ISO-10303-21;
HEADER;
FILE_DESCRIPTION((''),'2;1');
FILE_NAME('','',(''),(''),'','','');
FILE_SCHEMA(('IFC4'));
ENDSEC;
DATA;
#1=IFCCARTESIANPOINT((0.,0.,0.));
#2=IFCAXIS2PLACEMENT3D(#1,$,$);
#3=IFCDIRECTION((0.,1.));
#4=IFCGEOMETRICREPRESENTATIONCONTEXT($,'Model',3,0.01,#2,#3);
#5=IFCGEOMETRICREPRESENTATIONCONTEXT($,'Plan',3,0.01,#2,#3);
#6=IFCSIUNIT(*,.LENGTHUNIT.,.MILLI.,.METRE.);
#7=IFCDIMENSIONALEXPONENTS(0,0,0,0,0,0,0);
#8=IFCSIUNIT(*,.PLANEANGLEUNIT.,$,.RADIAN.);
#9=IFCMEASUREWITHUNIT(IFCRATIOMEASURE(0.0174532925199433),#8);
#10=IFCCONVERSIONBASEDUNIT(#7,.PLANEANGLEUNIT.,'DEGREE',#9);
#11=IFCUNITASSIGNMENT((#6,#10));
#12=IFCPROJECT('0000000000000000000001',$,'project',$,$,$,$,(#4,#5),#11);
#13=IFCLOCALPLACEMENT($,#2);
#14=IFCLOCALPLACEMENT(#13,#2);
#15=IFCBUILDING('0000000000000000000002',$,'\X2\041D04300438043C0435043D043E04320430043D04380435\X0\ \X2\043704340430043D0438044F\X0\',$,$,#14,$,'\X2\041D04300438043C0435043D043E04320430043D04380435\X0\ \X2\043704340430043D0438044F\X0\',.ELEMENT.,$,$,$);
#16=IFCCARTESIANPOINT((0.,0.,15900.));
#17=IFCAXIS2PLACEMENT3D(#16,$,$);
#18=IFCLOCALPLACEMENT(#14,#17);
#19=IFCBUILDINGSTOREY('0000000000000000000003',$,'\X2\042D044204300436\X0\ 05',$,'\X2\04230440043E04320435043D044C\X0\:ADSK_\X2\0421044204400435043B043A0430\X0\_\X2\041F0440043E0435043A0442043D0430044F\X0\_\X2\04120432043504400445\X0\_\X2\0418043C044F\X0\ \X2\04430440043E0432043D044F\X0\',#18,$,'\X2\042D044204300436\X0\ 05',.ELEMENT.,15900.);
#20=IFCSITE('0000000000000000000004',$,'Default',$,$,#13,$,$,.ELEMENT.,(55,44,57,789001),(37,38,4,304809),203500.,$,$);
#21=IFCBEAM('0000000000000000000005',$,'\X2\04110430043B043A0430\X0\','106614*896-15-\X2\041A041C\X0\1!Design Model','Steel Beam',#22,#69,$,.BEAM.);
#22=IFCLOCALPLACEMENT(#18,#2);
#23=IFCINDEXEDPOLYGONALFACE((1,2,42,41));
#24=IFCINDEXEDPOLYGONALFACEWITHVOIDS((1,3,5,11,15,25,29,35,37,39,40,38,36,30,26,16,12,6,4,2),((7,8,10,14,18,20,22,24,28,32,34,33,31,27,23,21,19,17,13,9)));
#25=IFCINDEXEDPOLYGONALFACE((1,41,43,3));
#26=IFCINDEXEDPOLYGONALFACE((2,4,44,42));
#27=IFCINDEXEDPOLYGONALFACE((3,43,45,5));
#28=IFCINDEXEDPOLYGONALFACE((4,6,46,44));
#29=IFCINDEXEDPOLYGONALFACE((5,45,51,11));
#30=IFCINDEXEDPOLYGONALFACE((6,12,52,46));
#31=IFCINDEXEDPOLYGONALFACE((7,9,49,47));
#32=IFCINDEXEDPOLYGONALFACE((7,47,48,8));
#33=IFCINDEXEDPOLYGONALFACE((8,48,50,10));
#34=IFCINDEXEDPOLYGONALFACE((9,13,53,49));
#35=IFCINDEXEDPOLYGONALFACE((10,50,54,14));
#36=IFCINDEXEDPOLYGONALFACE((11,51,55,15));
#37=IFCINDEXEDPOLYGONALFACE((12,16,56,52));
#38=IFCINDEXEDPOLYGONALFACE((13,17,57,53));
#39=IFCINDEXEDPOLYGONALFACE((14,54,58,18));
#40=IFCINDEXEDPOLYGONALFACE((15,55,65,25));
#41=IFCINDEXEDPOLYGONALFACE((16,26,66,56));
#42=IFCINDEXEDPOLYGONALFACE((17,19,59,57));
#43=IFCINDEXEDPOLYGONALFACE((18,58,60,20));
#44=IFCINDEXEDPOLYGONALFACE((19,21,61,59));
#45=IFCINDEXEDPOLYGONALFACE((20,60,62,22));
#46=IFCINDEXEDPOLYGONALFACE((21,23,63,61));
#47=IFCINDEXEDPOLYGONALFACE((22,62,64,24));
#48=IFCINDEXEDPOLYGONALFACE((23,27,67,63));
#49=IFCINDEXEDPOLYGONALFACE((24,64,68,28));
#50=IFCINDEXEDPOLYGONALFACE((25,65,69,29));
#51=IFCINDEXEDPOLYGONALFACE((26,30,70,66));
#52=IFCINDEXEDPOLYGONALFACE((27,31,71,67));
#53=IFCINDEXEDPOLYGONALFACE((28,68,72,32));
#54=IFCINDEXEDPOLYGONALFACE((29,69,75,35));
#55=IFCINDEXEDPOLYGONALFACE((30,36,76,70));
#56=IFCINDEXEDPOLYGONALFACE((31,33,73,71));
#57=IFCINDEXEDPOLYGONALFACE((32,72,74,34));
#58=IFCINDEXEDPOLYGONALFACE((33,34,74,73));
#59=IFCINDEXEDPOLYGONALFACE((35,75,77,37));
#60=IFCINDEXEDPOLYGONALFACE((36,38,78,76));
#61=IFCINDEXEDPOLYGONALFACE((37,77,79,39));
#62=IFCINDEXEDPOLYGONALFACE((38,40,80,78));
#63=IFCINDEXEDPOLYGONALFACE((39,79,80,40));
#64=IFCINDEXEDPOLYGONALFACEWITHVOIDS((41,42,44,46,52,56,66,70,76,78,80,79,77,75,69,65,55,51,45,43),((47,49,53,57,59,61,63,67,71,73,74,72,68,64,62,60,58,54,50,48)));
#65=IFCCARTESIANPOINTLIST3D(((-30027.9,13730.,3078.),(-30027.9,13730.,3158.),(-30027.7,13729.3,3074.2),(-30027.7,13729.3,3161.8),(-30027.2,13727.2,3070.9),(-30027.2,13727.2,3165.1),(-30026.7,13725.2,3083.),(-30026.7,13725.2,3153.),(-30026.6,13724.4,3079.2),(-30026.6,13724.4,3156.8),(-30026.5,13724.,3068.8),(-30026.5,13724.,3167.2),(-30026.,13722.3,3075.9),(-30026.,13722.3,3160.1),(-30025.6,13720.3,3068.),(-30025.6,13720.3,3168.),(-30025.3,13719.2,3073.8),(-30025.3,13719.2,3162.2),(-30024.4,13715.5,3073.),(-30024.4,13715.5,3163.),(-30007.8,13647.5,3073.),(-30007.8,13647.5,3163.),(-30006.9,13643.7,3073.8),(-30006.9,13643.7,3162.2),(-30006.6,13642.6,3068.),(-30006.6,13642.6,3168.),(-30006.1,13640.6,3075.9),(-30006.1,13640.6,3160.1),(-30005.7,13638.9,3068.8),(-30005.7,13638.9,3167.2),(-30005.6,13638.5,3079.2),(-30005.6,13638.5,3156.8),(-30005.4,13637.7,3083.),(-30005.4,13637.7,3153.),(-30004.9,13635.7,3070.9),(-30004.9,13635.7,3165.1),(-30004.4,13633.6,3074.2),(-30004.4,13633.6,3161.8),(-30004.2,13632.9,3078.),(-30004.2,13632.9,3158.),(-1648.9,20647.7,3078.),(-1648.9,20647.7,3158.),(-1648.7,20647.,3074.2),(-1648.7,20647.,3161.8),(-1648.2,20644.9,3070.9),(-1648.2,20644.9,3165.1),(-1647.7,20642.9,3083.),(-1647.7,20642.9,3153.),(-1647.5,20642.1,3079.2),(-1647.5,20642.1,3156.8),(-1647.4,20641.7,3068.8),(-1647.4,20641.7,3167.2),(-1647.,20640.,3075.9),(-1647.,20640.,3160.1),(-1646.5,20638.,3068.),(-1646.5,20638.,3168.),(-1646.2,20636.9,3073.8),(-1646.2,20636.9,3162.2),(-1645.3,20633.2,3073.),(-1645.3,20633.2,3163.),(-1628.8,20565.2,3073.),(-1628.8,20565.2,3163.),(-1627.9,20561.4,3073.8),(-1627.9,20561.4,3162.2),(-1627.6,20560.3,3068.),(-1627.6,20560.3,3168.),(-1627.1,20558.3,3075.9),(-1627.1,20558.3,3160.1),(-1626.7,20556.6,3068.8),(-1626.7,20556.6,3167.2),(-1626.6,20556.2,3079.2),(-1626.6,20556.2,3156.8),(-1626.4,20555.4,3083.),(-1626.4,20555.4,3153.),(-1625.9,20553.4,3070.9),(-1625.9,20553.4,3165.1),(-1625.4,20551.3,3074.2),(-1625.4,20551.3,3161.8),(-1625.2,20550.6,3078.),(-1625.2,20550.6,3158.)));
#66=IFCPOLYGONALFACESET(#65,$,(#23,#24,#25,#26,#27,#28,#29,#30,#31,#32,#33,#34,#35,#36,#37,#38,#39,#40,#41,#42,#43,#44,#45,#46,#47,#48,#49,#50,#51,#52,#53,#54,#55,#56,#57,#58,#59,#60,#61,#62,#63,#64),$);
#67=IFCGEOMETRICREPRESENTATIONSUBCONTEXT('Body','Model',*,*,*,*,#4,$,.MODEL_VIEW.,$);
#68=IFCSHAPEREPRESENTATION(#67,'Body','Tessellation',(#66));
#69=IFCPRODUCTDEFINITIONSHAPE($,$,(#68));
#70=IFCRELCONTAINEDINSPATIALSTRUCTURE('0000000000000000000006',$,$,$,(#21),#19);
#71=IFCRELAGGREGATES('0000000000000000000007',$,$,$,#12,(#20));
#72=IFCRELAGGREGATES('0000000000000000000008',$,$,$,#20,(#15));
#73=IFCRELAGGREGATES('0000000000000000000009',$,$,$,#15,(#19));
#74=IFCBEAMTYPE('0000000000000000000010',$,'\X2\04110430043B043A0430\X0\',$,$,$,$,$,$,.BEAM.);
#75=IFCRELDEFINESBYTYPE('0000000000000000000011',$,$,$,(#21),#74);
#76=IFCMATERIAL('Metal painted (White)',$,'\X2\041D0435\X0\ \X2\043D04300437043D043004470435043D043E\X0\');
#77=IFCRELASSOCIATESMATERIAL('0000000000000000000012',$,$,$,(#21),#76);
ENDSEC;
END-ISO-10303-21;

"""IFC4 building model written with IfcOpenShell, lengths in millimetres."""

from ifc_helpers import new_model, entity, si_unit, converted_unit, direction, frame, origin, place, context, subcontext, project, spatial, indexed_curve, outline, extrude, material, type_object, element, save


model = new_model("IFC4")

# Units and contexts
model_context = context("Model", 3, precision=0.01, world=origin(), true_north=direction((0.0, 1.0)))
plan_context = context("Plan", 3, precision=0.01, world=origin(), true_north=direction((0.0, 1.0)))
body_context = subcontext(model_context, "Body", "Model", "MODEL_VIEW")
ifc_project = project(units=[si_unit("LENGTHUNIT", "METRE", prefix="MILLI"), converted_unit("PLANEANGLEUNIT", "DEGREE", entity("IfcRatioMeasure", 0.0174532925199433), si_unit("PLANEANGLEUNIT", "RADIAN"), dimensions=[0, 0, 0, 0, 0, 0, 0])], contexts=[model_context, plan_context])

# Site, building, storey
site_placement = place(None, origin())
site = spatial("IfcSite", under=ifc_project, at=site_placement, Name="Default", CompositionType="ELEMENT", RefLatitude=(55, 44, 57, 789001), RefLongitude=(37, 38, 4, 304809), RefElevation=203500.0)
building_placement = place(site_placement, origin())
building = spatial("IfcBuilding", under=site, at=building_placement, Name="Наименование здания", LongName="Наименование здания", CompositionType="ELEMENT")
storey_placement = place(building_placement, frame((0.0, 0.0, 15900.0)))
storey = spatial("IfcBuildingStorey", under=building, at=storey_placement, Name="Этаж 05", ObjectType="Уровень:ADSK_Стрелка_Проектная_Вверх_Имя уровня", LongName="Этаж 05", CompositionType="ELEMENT", Elevation=15900.0)

# Beam
ifc_material = material(Name="Metal painted (White)", Category="Не назначено")
beam_type = type_object("IfcBeamType", Name="Балка", PredefinedType="BEAM")
beam_1_placement = place(storey_placement, origin())
element("IfcBeam", 1, at=beam_1_placement, inside=storey, type_object=beam_type, material=ifc_material, Name="Балка", Description="106614*896-15-КМ1!Design Model", ObjectType="Steel Beam", PredefinedType="BEAM", context=body_context, shape_type="SweptSolid", body=[
    extrude(outline(indexed_curve([(29.5, -56.8), (33.4, -56.8), (37.0, -55.3), (39.7, -52.6), (41.2, -49.0), (56.8, 29.5), (56.8, 33.4), (55.3, 37.0), (52.6, 39.7), (49.0, 41.2), (-29.5, 56.8), (-33.4, 56.8), (-37.0, 55.3), (-39.7, 52.6), (-41.2, 49.0), (-56.8, -29.5), (-56.8, -33.4), (-55.3, -37.0), (-52.6, -39.7), (-49.0, -41.2), (29.5, -56.8)], self_intersect=False), holes=[indexed_curve([(-51.0, -25.5), (-37.3, 43.1), (-35.8, 46.7), (-33.1, 49.5), (-29.5, 51.0), (-25.5, 51.0), (43.1, 37.3), (46.7, 35.8), (49.5, 33.1), (51.0, 29.5), (51.0, 25.5), (37.3, -43.1), (35.8, -46.7), (33.1, -49.5), (29.5, -51.0), (25.5, -51.0), (-43.1, -37.3), (-46.7, -35.8), (-49.5, -33.1), (-51.0, -29.5), (-51.0, -25.5)], self_intersect=False)]), frame((-30016.1, 13681.5, 3118.0), z_axis=(0.971552, 0.236826, 0.0), x_axis=(-0.232276, 0.952884, 0.19509)), (0.0, 0.0, 1.0), 29210.0),
])

save(model, "model.ifc")
